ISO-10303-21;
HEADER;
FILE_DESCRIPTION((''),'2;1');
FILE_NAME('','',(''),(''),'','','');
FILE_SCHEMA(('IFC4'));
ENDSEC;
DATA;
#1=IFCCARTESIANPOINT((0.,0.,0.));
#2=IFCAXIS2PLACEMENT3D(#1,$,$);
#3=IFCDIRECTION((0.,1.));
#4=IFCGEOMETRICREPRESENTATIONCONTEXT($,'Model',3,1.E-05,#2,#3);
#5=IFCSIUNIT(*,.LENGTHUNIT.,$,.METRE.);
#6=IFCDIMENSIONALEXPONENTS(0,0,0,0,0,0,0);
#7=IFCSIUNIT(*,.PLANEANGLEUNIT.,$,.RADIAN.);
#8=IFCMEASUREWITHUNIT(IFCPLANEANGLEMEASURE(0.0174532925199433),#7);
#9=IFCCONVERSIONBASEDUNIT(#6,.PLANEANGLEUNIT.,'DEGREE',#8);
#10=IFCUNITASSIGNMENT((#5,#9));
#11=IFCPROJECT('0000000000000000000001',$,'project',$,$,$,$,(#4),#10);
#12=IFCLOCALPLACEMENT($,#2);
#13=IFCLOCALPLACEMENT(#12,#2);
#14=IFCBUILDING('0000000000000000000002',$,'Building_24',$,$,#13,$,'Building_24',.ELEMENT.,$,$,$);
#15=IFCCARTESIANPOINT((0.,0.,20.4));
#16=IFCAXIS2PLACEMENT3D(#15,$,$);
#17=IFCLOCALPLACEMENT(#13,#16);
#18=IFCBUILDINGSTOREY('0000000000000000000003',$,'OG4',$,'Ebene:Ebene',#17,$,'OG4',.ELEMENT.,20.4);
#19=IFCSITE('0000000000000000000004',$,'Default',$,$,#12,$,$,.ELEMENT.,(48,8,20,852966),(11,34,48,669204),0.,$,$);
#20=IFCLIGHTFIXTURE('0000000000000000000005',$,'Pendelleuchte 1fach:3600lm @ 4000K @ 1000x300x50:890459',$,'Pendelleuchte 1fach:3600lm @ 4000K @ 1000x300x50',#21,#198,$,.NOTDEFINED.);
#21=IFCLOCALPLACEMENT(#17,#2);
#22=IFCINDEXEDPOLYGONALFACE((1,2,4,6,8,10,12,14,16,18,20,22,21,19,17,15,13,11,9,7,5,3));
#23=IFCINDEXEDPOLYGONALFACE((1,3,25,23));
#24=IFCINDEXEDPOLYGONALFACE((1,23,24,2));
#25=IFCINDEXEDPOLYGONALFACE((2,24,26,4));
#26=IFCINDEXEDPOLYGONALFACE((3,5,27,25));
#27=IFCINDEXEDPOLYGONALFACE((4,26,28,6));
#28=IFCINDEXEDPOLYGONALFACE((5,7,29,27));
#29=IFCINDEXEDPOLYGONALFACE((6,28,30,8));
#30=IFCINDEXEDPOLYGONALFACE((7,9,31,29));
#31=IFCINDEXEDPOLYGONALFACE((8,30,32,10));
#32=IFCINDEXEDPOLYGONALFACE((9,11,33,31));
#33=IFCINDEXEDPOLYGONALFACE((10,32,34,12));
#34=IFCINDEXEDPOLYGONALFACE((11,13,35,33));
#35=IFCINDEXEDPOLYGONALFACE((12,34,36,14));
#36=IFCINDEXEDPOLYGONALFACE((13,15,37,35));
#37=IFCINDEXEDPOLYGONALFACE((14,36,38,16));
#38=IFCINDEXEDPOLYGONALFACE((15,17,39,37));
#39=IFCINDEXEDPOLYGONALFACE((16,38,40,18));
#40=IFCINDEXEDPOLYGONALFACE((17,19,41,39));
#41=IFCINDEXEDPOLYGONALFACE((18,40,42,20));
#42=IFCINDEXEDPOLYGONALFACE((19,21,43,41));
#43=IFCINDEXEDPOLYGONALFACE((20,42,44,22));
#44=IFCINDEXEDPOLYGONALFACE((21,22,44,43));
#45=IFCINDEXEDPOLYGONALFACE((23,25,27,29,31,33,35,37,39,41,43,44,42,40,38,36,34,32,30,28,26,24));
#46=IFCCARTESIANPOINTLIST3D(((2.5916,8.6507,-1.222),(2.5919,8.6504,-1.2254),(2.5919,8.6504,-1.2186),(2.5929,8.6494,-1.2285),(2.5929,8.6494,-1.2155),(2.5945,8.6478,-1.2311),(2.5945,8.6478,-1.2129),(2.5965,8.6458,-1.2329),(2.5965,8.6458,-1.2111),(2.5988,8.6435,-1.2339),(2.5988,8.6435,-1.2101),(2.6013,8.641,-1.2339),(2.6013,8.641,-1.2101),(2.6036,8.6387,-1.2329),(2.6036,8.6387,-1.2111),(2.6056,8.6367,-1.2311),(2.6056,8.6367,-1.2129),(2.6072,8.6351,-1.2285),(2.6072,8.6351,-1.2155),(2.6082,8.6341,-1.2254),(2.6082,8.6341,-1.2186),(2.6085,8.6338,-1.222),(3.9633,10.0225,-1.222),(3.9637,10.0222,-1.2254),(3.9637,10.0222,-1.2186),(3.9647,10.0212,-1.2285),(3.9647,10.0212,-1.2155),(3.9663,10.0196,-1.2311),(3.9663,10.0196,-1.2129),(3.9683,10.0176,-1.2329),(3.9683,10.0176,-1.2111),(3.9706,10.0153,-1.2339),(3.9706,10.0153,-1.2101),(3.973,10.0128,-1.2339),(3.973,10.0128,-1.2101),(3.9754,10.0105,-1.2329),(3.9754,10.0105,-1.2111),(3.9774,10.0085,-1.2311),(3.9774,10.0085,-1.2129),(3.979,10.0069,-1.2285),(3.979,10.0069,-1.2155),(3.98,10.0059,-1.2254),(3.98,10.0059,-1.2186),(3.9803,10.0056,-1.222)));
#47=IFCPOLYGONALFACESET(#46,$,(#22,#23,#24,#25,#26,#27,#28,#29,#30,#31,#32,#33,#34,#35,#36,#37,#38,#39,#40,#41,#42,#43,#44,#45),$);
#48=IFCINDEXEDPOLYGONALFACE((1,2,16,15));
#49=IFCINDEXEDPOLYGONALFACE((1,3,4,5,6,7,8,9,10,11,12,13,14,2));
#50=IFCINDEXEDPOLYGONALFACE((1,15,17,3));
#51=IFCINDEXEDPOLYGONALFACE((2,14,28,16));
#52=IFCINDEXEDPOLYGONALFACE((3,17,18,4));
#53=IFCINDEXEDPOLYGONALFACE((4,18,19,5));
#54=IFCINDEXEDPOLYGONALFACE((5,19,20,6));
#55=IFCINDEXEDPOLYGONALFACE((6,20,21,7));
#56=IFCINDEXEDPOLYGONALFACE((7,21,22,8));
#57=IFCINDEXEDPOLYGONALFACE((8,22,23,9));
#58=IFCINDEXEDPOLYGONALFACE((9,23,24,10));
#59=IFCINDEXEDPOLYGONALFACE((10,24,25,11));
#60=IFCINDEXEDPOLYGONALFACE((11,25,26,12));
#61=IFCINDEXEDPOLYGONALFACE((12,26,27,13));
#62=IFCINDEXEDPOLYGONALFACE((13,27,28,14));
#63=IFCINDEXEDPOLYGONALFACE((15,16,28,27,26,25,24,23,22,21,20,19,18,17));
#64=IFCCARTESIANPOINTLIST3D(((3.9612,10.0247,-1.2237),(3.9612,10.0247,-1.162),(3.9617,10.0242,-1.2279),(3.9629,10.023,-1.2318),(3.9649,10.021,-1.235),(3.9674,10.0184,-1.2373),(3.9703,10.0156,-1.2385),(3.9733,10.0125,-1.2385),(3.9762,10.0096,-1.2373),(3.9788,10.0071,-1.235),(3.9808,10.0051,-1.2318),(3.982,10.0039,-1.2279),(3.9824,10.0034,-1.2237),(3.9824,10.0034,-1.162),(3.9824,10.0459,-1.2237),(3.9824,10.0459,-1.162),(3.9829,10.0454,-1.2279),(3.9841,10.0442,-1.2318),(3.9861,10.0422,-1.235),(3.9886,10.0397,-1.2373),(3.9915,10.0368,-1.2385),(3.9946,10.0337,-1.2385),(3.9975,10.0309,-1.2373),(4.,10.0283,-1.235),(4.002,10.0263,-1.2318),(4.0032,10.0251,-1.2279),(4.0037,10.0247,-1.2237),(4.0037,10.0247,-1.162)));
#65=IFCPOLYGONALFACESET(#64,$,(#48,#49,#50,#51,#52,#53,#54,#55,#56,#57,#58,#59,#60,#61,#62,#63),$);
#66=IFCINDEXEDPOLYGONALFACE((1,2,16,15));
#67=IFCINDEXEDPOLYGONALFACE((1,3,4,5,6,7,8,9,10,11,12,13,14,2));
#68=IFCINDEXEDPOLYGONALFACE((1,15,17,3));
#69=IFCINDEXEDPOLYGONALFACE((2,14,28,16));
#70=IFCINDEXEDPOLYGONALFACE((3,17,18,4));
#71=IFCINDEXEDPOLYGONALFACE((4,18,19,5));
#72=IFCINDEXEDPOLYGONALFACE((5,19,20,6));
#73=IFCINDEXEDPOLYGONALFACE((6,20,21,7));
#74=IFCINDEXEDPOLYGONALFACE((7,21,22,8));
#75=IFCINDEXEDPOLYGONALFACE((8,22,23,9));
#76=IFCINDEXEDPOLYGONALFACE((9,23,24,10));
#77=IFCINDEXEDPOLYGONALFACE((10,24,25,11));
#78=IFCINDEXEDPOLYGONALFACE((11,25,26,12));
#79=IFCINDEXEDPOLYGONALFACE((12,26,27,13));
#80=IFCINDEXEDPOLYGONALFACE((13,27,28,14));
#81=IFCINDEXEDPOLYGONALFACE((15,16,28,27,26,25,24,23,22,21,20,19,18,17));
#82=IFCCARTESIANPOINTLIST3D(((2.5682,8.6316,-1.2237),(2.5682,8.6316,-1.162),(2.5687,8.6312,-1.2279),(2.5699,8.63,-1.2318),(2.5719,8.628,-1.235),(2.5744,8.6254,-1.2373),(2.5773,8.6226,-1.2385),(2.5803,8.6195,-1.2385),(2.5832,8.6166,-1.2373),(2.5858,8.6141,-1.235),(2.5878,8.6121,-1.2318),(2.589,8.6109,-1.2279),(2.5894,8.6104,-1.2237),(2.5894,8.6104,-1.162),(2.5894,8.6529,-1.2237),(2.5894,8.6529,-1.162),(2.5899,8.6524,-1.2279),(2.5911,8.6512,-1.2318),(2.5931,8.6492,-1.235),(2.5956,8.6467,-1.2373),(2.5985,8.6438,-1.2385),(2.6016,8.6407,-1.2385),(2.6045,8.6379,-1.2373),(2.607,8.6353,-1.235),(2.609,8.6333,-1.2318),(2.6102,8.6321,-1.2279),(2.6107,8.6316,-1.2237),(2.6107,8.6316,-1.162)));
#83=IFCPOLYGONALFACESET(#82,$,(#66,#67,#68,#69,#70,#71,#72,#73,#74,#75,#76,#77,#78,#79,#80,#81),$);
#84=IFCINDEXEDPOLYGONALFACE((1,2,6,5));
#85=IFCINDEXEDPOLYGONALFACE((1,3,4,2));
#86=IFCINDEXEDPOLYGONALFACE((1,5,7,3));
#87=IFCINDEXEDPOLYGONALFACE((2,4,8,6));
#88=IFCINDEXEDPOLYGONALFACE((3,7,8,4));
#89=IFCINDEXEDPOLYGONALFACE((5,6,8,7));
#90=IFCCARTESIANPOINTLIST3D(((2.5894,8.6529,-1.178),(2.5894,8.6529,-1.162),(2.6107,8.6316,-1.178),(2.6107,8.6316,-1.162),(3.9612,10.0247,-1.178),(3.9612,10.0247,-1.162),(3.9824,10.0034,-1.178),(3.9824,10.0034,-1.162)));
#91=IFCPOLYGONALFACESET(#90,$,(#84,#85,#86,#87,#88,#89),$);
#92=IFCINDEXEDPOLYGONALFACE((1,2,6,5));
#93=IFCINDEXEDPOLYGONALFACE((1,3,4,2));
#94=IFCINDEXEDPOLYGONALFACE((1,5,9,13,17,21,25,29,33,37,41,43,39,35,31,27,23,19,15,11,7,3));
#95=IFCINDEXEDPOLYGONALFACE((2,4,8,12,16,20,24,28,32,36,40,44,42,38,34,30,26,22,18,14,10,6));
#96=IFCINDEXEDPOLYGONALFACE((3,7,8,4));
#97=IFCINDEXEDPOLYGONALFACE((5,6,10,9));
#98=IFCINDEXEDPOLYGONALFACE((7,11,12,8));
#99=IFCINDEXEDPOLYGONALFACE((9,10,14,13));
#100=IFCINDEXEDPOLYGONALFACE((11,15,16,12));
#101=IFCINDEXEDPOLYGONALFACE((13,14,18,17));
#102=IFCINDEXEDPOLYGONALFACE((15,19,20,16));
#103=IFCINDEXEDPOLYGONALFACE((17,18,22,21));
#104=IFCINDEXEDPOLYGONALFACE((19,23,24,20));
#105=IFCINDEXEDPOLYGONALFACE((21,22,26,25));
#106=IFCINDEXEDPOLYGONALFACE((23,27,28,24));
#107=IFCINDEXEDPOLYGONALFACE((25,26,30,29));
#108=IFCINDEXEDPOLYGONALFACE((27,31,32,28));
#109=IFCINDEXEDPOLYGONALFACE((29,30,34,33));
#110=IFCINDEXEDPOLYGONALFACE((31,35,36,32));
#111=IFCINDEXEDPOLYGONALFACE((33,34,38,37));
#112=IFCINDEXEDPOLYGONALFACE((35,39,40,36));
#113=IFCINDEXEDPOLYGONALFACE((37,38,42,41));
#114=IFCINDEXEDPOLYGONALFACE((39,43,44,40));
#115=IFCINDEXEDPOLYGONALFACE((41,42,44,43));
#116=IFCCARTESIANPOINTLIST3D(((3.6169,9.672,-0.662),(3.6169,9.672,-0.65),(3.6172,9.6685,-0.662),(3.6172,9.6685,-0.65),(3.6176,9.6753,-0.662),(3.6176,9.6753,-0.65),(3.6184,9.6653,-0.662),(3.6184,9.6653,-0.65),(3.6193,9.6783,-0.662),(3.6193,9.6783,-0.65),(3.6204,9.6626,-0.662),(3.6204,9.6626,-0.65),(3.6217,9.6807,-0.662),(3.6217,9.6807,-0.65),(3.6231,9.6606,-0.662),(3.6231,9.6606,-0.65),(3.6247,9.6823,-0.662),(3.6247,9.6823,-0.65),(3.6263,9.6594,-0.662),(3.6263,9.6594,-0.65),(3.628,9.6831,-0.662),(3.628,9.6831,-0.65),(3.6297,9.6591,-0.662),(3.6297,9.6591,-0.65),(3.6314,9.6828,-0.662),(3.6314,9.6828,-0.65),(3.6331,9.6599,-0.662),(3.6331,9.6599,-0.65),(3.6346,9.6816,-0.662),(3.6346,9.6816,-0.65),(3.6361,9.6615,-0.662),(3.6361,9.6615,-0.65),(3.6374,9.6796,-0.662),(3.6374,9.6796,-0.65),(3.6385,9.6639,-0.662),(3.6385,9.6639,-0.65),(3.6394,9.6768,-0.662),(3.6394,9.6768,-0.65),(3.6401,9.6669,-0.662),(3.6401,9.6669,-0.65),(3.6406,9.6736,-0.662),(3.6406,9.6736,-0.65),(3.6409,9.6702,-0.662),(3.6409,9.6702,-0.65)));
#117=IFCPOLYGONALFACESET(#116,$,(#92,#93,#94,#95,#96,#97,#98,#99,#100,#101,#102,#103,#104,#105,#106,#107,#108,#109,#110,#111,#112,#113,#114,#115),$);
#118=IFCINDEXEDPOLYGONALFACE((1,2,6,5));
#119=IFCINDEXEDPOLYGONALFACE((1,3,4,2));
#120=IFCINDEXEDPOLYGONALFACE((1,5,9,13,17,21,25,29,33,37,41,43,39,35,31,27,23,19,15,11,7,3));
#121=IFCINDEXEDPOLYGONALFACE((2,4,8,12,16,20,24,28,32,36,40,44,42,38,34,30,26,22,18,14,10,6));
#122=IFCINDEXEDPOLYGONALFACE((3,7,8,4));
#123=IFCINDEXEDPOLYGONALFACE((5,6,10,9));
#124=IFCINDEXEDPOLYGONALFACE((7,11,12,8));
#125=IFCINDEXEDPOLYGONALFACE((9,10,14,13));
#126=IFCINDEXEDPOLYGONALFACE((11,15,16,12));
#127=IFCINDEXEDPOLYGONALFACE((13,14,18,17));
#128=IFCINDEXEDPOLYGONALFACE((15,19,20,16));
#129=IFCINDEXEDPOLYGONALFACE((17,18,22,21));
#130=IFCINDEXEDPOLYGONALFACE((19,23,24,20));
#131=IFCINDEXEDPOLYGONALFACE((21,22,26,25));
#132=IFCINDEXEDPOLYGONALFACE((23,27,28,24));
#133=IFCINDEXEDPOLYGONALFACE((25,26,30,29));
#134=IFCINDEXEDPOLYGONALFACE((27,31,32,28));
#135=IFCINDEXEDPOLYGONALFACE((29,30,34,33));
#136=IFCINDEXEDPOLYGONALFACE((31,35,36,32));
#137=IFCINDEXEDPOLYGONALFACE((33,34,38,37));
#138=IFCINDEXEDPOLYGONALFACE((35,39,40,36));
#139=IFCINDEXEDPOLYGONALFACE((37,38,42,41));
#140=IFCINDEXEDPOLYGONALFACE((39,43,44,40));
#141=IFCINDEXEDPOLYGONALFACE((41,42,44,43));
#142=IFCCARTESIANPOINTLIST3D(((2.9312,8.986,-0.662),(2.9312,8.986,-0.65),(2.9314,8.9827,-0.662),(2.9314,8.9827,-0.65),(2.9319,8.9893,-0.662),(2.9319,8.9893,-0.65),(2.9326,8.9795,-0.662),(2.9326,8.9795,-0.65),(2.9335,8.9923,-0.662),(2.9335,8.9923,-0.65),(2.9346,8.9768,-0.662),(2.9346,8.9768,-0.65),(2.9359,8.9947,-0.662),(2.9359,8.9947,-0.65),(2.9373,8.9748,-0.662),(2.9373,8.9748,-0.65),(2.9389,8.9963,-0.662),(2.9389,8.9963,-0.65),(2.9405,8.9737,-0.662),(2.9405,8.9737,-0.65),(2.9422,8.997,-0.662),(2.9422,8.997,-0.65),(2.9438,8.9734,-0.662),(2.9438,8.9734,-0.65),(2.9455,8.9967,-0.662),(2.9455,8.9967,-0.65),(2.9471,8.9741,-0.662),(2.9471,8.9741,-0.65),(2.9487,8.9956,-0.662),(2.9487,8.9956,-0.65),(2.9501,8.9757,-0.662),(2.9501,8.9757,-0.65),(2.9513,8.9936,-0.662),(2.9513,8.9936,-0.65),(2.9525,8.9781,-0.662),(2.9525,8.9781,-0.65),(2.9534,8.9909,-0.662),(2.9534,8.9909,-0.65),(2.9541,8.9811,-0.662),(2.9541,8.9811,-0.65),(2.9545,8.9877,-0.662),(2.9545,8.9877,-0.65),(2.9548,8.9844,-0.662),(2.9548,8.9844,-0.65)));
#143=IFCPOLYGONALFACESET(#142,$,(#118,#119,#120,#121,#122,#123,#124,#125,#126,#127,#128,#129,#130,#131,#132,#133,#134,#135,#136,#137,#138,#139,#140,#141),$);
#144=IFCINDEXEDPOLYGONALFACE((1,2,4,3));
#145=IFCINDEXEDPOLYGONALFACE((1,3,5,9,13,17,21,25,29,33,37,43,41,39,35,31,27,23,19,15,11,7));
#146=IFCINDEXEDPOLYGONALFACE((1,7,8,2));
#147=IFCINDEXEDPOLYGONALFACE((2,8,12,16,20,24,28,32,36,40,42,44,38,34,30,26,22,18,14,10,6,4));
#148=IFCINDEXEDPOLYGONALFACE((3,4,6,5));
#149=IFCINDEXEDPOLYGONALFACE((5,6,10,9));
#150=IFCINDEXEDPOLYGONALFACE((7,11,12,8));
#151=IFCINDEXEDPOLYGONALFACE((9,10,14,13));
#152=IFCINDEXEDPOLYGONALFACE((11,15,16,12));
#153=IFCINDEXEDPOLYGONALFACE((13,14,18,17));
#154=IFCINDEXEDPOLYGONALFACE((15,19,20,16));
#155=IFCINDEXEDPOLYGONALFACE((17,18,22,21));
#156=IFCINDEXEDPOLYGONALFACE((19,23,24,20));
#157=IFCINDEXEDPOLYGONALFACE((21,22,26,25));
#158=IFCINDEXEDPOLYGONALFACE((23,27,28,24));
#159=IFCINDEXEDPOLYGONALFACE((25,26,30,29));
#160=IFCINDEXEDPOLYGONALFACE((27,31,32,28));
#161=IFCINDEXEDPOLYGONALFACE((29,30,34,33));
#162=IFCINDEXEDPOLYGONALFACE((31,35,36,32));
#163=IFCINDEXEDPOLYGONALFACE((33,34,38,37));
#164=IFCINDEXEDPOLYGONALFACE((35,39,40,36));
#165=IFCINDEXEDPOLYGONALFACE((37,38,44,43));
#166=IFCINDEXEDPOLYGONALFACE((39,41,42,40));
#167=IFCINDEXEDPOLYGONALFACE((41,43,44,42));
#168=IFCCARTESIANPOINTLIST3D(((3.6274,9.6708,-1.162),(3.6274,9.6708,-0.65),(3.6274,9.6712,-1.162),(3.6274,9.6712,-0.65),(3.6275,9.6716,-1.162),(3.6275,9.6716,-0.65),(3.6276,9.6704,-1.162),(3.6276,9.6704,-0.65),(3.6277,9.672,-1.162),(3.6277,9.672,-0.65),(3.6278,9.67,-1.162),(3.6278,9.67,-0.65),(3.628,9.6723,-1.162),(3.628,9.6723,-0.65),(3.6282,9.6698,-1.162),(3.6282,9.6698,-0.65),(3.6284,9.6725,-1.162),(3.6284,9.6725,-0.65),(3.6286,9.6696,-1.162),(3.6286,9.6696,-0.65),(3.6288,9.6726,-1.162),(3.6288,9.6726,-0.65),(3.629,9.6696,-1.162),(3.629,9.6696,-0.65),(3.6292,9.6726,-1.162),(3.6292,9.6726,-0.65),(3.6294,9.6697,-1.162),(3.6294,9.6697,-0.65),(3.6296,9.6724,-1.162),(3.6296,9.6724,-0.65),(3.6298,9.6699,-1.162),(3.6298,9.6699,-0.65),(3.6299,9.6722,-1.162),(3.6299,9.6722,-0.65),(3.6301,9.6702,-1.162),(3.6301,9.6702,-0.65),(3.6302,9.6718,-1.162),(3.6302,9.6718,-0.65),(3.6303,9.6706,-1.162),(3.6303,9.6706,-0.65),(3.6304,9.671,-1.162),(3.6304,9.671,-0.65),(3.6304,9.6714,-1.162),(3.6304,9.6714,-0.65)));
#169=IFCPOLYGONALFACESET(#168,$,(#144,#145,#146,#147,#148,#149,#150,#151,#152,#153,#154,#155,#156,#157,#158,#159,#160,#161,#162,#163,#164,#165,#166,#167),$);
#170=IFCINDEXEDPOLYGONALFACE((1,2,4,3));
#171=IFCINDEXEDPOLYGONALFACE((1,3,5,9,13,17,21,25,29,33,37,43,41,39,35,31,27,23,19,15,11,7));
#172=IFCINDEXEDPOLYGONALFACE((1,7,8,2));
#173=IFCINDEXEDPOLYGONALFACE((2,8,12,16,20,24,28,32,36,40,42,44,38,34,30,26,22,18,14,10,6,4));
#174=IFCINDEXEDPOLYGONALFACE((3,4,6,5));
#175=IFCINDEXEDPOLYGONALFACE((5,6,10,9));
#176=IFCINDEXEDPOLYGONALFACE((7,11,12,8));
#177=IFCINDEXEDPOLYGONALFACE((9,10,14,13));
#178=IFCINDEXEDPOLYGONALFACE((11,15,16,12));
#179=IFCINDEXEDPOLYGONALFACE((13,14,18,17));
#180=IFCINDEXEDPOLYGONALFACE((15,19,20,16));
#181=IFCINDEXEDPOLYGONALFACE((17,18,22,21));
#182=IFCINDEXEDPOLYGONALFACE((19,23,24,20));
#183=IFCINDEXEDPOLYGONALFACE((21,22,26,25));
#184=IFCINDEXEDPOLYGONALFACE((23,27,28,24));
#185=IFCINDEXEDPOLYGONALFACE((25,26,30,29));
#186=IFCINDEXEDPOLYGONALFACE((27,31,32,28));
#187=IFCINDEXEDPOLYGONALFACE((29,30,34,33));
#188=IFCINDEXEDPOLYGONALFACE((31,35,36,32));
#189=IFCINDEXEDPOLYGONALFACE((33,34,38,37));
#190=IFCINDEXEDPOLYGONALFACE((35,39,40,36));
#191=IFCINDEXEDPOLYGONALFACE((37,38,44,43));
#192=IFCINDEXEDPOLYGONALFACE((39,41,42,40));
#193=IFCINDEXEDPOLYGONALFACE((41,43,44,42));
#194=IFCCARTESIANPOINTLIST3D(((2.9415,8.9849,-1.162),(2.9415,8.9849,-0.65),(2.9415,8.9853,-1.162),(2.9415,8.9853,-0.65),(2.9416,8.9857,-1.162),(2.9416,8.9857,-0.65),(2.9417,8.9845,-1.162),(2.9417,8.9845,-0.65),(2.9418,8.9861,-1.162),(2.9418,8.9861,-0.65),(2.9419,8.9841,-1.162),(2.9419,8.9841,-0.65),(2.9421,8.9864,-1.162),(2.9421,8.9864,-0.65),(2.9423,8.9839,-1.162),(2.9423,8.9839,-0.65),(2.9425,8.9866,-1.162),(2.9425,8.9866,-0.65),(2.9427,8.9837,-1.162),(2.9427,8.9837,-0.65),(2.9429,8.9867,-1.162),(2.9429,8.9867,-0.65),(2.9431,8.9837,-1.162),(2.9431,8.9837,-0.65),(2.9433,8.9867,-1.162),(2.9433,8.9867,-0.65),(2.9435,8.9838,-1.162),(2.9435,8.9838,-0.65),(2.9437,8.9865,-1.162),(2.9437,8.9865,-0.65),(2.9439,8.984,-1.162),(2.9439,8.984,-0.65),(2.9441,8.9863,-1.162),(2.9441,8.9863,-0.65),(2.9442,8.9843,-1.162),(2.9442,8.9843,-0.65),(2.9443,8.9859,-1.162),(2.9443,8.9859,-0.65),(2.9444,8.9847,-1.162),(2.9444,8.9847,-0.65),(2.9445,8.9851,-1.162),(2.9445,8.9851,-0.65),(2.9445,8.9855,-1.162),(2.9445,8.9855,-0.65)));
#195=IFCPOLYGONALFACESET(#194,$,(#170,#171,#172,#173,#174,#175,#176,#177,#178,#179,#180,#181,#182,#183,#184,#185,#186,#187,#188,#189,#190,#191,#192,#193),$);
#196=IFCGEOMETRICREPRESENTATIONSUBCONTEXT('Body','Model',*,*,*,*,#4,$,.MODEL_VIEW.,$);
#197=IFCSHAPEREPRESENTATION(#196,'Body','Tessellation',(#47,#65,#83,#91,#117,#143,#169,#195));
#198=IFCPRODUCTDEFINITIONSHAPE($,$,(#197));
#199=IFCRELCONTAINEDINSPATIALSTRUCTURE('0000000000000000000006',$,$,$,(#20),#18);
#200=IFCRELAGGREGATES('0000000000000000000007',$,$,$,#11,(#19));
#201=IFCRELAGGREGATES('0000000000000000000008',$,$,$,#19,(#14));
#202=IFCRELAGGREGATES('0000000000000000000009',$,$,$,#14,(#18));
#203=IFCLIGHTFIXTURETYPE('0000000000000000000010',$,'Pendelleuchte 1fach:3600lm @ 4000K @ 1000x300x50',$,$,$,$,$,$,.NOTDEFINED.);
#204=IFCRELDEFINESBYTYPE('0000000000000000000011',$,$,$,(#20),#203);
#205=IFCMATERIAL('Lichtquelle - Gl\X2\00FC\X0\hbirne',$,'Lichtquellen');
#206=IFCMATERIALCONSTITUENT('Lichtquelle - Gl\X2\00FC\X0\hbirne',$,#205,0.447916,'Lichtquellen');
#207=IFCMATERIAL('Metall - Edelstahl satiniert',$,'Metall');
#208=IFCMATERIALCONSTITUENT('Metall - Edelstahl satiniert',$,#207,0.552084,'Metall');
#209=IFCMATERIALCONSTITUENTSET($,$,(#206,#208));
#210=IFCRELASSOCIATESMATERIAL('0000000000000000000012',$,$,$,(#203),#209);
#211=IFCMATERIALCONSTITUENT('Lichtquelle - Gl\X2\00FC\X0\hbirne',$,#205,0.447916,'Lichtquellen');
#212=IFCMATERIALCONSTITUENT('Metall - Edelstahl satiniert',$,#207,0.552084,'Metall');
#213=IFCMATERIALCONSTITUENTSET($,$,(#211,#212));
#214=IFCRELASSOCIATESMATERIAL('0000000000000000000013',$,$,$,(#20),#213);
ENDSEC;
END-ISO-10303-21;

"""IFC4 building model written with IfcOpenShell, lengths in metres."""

from ifc_helpers import new_model, entity, si_unit, converted_unit, direction, frame, origin, place, context, subcontext, project, spatial, line, arc, indexed_curve, outline, extrude, source, transform, mapped, material, constituent, constituent_set, type_object, type_shapes, element, save


model = new_model("IFC4")

# Units and contexts
model_context = context("Model", 3, precision=1e-05, world=origin(), true_north=direction((0.0, 1.0)))
body_context = subcontext(model_context, "Body", "Model", "MODEL_VIEW")
ifc_project = project(units=[si_unit("LENGTHUNIT", "METRE"), converted_unit("PLANEANGLEUNIT", "DEGREE", entity("IfcPlaneAngleMeasure", 0.0174532925199433), si_unit("PLANEANGLEUNIT", "RADIAN"), dimensions=[0, 0, 0, 0, 0, 0, 0])], contexts=[model_context])

# Site, building, storey
site_placement = place(None, origin())
site = spatial("IfcSite", under=ifc_project, at=site_placement, Name="Default", CompositionType="ELEMENT", RefLatitude=(48, 8, 20, 852966), RefLongitude=(11, 34, 48, 669204), RefElevation=0.0)
building_placement = place(site_placement, origin())
building = spatial("IfcBuilding", under=site, at=building_placement, Name="Building_24", LongName="Building_24", CompositionType="ELEMENT")
storey_placement = place(building_placement, frame((0.0, 0.0, 20.4)))
storey = spatial("IfcBuildingStorey", under=building, at=storey_placement, Name="OG4", ObjectType="Ebene:Ebene", LongName="OG4", CompositionType="ELEMENT", Elevation=20.4)

# Light fixture
ifc_material_1 = material(Name="Lichtquelle - Glühbirne", Category="Lichtquellen")
ifc_material_2 = material(Name="Metall - Edelstahl satiniert", Category="Metall")
ifc_constituent_1 = constituent(ifc_material_1, Name="Lichtquelle - Glühbirne", Category="Lichtquellen", fraction=0.447916)
ifc_constituent_2 = constituent(ifc_material_2, Name="Metall - Edelstahl satiniert", Category="Metall", fraction=0.552084)
ifc_constituent_set_1 = constituent_set(constituents=[ifc_constituent_1, ifc_constituent_2])
light_fixture_type = type_object("IfcLightFixtureType", Name="Pendelleuchte 1fach:3600lm @ 4000K @ 1000x300x50", PredefinedType="NOTDEFINED", material=ifc_constituent_set_1)
shared_shape_1 = source(origin(), body_context, "Body", "SweptSolid", [
    extrude(outline(indexed_curve([(-0.012, 0.0), (0.0, -0.012), (0.012, 0.0), (0.0, 0.012)], segments=[arc(1, 2, 3), arc(3, 4, 1)], self_intersect=False)), frame((-0.97, 0.0, -0.572), z_axis=(1.0, 0.0, 0.0), x_axis=(0.0, 1.0, 0.0)), (0.0, 0.0, 1.0), 1.94),
    extrude(outline(indexed_curve([(-0.0308, -0.015), (0.0308, -0.015), (0.0308, 0.015), (-0.0308, 0.015), (-0.0458, 0.0)], segments=[line(1, 2, 3, 4), arc(4, 5, 1)], self_intersect=False)), frame((0.97, 0.0, -0.5428), z_axis=(1.0, 0.0, 0.0), x_axis=(0.0, 0.0, 1.0)), (0.0, 0.0, 1.0), 0.03),
    extrude(outline(indexed_curve([(-0.0308, -0.015), (0.0308, -0.015), (0.0308, 0.015), (-0.0308, 0.015), (-0.0458, 0.0)], segments=[line(1, 2, 3, 4), arc(4, 5, 1)], self_intersect=False)), frame((-1.0, 0.0, -0.5428), z_axis=(1.0, 0.0, 0.0), x_axis=(0.0, 0.0, 1.0)), (0.0, 0.0, 1.0), 0.03),
    extrude(outline(indexed_curve([(-0.97, -0.015), (0.97, -0.015), (0.97, 0.015), (-0.97, 0.015), (-0.97, -0.015)], self_intersect=False)), frame((0.0, 0.0, -0.528), z_axis=(0.0, 0.0, 1.0), x_axis=(-1.0, 0.0, 0.0)), (0.0, 0.0, 1.0), 0.016),
    extrude(outline(indexed_curve([(-0.012, 0.0), (0.0, -0.012), (0.012, 0.0), (0.0, 0.012)], segments=[arc(1, 2, 3), arc(3, 4, 1)], self_intersect=False)), frame((0.485, 0.0, -0.012)), (0.0, 0.0, 1.0), 0.012),
    extrude(outline(indexed_curve([(-0.0118, 0.0), (0.0, -0.0118), (0.0118, 0.0), (0.0, 0.0118)], segments=[arc(1, 2, 3), arc(3, 4, 1)], self_intersect=False)), frame((-0.485, 0.0, -0.012)), (0.0, 0.0, 1.0), 0.012),
    extrude(outline(indexed_curve([(-0.0015, 0.0), (0.0, -0.0015), (0.0015, 0.0), (0.0, 0.0015)], segments=[arc(1, 2, 3), arc(3, 4, 1)], self_intersect=False)), frame((0.485, 0.0, -0.512)), (0.0, 0.0, 1.0), 0.512),
    extrude(outline(indexed_curve([(-0.0015, 0.0), (0.0, -0.0015), (0.0015, 0.0), (0.0, 0.0015)], segments=[arc(1, 2, 3), arc(3, 4, 1)], self_intersect=False)), frame((-0.485, 0.0, -0.512)), (0.0, 0.0, 1.0), 0.512),
])
type_shapes(light_fixture_type, [shared_shape_1])
ifc_constituent_3 = constituent(ifc_material_1, Name="Lichtquelle - Glühbirne", Category="Lichtquellen", fraction=0.447916)
ifc_constituent_4 = constituent(ifc_material_2, Name="Metall - Edelstahl satiniert", Category="Metall", fraction=0.552084)
ifc_constituent_set_2 = constituent_set(constituents=[ifc_constituent_3, ifc_constituent_4])
light_fixture_1_placement = place(storey_placement, frame((3.2859, 9.3281, -0.65), z_axis=(0.0, 0.0, 1.0), x_axis=(0.707107, 0.707107, 0.0)))
element("IfcLightFixture", 1, at=light_fixture_1_placement, inside=storey, type_object=light_fixture_type, material=ifc_constituent_set_2, Name="Pendelleuchte 1fach:3600lm @ 4000K @ 1000x300x50:890459", ObjectType="Pendelleuchte 1fach:3600lm @ 4000K @ 1000x300x50", PredefinedType="NOTDEFINED", context=body_context, shape_type="MappedRepresentation", body=[
    mapped(shared_shape_1, transform((0.0, 0.0, 0.0), scale=1.0)),
])

save(model, "model.ifc")
